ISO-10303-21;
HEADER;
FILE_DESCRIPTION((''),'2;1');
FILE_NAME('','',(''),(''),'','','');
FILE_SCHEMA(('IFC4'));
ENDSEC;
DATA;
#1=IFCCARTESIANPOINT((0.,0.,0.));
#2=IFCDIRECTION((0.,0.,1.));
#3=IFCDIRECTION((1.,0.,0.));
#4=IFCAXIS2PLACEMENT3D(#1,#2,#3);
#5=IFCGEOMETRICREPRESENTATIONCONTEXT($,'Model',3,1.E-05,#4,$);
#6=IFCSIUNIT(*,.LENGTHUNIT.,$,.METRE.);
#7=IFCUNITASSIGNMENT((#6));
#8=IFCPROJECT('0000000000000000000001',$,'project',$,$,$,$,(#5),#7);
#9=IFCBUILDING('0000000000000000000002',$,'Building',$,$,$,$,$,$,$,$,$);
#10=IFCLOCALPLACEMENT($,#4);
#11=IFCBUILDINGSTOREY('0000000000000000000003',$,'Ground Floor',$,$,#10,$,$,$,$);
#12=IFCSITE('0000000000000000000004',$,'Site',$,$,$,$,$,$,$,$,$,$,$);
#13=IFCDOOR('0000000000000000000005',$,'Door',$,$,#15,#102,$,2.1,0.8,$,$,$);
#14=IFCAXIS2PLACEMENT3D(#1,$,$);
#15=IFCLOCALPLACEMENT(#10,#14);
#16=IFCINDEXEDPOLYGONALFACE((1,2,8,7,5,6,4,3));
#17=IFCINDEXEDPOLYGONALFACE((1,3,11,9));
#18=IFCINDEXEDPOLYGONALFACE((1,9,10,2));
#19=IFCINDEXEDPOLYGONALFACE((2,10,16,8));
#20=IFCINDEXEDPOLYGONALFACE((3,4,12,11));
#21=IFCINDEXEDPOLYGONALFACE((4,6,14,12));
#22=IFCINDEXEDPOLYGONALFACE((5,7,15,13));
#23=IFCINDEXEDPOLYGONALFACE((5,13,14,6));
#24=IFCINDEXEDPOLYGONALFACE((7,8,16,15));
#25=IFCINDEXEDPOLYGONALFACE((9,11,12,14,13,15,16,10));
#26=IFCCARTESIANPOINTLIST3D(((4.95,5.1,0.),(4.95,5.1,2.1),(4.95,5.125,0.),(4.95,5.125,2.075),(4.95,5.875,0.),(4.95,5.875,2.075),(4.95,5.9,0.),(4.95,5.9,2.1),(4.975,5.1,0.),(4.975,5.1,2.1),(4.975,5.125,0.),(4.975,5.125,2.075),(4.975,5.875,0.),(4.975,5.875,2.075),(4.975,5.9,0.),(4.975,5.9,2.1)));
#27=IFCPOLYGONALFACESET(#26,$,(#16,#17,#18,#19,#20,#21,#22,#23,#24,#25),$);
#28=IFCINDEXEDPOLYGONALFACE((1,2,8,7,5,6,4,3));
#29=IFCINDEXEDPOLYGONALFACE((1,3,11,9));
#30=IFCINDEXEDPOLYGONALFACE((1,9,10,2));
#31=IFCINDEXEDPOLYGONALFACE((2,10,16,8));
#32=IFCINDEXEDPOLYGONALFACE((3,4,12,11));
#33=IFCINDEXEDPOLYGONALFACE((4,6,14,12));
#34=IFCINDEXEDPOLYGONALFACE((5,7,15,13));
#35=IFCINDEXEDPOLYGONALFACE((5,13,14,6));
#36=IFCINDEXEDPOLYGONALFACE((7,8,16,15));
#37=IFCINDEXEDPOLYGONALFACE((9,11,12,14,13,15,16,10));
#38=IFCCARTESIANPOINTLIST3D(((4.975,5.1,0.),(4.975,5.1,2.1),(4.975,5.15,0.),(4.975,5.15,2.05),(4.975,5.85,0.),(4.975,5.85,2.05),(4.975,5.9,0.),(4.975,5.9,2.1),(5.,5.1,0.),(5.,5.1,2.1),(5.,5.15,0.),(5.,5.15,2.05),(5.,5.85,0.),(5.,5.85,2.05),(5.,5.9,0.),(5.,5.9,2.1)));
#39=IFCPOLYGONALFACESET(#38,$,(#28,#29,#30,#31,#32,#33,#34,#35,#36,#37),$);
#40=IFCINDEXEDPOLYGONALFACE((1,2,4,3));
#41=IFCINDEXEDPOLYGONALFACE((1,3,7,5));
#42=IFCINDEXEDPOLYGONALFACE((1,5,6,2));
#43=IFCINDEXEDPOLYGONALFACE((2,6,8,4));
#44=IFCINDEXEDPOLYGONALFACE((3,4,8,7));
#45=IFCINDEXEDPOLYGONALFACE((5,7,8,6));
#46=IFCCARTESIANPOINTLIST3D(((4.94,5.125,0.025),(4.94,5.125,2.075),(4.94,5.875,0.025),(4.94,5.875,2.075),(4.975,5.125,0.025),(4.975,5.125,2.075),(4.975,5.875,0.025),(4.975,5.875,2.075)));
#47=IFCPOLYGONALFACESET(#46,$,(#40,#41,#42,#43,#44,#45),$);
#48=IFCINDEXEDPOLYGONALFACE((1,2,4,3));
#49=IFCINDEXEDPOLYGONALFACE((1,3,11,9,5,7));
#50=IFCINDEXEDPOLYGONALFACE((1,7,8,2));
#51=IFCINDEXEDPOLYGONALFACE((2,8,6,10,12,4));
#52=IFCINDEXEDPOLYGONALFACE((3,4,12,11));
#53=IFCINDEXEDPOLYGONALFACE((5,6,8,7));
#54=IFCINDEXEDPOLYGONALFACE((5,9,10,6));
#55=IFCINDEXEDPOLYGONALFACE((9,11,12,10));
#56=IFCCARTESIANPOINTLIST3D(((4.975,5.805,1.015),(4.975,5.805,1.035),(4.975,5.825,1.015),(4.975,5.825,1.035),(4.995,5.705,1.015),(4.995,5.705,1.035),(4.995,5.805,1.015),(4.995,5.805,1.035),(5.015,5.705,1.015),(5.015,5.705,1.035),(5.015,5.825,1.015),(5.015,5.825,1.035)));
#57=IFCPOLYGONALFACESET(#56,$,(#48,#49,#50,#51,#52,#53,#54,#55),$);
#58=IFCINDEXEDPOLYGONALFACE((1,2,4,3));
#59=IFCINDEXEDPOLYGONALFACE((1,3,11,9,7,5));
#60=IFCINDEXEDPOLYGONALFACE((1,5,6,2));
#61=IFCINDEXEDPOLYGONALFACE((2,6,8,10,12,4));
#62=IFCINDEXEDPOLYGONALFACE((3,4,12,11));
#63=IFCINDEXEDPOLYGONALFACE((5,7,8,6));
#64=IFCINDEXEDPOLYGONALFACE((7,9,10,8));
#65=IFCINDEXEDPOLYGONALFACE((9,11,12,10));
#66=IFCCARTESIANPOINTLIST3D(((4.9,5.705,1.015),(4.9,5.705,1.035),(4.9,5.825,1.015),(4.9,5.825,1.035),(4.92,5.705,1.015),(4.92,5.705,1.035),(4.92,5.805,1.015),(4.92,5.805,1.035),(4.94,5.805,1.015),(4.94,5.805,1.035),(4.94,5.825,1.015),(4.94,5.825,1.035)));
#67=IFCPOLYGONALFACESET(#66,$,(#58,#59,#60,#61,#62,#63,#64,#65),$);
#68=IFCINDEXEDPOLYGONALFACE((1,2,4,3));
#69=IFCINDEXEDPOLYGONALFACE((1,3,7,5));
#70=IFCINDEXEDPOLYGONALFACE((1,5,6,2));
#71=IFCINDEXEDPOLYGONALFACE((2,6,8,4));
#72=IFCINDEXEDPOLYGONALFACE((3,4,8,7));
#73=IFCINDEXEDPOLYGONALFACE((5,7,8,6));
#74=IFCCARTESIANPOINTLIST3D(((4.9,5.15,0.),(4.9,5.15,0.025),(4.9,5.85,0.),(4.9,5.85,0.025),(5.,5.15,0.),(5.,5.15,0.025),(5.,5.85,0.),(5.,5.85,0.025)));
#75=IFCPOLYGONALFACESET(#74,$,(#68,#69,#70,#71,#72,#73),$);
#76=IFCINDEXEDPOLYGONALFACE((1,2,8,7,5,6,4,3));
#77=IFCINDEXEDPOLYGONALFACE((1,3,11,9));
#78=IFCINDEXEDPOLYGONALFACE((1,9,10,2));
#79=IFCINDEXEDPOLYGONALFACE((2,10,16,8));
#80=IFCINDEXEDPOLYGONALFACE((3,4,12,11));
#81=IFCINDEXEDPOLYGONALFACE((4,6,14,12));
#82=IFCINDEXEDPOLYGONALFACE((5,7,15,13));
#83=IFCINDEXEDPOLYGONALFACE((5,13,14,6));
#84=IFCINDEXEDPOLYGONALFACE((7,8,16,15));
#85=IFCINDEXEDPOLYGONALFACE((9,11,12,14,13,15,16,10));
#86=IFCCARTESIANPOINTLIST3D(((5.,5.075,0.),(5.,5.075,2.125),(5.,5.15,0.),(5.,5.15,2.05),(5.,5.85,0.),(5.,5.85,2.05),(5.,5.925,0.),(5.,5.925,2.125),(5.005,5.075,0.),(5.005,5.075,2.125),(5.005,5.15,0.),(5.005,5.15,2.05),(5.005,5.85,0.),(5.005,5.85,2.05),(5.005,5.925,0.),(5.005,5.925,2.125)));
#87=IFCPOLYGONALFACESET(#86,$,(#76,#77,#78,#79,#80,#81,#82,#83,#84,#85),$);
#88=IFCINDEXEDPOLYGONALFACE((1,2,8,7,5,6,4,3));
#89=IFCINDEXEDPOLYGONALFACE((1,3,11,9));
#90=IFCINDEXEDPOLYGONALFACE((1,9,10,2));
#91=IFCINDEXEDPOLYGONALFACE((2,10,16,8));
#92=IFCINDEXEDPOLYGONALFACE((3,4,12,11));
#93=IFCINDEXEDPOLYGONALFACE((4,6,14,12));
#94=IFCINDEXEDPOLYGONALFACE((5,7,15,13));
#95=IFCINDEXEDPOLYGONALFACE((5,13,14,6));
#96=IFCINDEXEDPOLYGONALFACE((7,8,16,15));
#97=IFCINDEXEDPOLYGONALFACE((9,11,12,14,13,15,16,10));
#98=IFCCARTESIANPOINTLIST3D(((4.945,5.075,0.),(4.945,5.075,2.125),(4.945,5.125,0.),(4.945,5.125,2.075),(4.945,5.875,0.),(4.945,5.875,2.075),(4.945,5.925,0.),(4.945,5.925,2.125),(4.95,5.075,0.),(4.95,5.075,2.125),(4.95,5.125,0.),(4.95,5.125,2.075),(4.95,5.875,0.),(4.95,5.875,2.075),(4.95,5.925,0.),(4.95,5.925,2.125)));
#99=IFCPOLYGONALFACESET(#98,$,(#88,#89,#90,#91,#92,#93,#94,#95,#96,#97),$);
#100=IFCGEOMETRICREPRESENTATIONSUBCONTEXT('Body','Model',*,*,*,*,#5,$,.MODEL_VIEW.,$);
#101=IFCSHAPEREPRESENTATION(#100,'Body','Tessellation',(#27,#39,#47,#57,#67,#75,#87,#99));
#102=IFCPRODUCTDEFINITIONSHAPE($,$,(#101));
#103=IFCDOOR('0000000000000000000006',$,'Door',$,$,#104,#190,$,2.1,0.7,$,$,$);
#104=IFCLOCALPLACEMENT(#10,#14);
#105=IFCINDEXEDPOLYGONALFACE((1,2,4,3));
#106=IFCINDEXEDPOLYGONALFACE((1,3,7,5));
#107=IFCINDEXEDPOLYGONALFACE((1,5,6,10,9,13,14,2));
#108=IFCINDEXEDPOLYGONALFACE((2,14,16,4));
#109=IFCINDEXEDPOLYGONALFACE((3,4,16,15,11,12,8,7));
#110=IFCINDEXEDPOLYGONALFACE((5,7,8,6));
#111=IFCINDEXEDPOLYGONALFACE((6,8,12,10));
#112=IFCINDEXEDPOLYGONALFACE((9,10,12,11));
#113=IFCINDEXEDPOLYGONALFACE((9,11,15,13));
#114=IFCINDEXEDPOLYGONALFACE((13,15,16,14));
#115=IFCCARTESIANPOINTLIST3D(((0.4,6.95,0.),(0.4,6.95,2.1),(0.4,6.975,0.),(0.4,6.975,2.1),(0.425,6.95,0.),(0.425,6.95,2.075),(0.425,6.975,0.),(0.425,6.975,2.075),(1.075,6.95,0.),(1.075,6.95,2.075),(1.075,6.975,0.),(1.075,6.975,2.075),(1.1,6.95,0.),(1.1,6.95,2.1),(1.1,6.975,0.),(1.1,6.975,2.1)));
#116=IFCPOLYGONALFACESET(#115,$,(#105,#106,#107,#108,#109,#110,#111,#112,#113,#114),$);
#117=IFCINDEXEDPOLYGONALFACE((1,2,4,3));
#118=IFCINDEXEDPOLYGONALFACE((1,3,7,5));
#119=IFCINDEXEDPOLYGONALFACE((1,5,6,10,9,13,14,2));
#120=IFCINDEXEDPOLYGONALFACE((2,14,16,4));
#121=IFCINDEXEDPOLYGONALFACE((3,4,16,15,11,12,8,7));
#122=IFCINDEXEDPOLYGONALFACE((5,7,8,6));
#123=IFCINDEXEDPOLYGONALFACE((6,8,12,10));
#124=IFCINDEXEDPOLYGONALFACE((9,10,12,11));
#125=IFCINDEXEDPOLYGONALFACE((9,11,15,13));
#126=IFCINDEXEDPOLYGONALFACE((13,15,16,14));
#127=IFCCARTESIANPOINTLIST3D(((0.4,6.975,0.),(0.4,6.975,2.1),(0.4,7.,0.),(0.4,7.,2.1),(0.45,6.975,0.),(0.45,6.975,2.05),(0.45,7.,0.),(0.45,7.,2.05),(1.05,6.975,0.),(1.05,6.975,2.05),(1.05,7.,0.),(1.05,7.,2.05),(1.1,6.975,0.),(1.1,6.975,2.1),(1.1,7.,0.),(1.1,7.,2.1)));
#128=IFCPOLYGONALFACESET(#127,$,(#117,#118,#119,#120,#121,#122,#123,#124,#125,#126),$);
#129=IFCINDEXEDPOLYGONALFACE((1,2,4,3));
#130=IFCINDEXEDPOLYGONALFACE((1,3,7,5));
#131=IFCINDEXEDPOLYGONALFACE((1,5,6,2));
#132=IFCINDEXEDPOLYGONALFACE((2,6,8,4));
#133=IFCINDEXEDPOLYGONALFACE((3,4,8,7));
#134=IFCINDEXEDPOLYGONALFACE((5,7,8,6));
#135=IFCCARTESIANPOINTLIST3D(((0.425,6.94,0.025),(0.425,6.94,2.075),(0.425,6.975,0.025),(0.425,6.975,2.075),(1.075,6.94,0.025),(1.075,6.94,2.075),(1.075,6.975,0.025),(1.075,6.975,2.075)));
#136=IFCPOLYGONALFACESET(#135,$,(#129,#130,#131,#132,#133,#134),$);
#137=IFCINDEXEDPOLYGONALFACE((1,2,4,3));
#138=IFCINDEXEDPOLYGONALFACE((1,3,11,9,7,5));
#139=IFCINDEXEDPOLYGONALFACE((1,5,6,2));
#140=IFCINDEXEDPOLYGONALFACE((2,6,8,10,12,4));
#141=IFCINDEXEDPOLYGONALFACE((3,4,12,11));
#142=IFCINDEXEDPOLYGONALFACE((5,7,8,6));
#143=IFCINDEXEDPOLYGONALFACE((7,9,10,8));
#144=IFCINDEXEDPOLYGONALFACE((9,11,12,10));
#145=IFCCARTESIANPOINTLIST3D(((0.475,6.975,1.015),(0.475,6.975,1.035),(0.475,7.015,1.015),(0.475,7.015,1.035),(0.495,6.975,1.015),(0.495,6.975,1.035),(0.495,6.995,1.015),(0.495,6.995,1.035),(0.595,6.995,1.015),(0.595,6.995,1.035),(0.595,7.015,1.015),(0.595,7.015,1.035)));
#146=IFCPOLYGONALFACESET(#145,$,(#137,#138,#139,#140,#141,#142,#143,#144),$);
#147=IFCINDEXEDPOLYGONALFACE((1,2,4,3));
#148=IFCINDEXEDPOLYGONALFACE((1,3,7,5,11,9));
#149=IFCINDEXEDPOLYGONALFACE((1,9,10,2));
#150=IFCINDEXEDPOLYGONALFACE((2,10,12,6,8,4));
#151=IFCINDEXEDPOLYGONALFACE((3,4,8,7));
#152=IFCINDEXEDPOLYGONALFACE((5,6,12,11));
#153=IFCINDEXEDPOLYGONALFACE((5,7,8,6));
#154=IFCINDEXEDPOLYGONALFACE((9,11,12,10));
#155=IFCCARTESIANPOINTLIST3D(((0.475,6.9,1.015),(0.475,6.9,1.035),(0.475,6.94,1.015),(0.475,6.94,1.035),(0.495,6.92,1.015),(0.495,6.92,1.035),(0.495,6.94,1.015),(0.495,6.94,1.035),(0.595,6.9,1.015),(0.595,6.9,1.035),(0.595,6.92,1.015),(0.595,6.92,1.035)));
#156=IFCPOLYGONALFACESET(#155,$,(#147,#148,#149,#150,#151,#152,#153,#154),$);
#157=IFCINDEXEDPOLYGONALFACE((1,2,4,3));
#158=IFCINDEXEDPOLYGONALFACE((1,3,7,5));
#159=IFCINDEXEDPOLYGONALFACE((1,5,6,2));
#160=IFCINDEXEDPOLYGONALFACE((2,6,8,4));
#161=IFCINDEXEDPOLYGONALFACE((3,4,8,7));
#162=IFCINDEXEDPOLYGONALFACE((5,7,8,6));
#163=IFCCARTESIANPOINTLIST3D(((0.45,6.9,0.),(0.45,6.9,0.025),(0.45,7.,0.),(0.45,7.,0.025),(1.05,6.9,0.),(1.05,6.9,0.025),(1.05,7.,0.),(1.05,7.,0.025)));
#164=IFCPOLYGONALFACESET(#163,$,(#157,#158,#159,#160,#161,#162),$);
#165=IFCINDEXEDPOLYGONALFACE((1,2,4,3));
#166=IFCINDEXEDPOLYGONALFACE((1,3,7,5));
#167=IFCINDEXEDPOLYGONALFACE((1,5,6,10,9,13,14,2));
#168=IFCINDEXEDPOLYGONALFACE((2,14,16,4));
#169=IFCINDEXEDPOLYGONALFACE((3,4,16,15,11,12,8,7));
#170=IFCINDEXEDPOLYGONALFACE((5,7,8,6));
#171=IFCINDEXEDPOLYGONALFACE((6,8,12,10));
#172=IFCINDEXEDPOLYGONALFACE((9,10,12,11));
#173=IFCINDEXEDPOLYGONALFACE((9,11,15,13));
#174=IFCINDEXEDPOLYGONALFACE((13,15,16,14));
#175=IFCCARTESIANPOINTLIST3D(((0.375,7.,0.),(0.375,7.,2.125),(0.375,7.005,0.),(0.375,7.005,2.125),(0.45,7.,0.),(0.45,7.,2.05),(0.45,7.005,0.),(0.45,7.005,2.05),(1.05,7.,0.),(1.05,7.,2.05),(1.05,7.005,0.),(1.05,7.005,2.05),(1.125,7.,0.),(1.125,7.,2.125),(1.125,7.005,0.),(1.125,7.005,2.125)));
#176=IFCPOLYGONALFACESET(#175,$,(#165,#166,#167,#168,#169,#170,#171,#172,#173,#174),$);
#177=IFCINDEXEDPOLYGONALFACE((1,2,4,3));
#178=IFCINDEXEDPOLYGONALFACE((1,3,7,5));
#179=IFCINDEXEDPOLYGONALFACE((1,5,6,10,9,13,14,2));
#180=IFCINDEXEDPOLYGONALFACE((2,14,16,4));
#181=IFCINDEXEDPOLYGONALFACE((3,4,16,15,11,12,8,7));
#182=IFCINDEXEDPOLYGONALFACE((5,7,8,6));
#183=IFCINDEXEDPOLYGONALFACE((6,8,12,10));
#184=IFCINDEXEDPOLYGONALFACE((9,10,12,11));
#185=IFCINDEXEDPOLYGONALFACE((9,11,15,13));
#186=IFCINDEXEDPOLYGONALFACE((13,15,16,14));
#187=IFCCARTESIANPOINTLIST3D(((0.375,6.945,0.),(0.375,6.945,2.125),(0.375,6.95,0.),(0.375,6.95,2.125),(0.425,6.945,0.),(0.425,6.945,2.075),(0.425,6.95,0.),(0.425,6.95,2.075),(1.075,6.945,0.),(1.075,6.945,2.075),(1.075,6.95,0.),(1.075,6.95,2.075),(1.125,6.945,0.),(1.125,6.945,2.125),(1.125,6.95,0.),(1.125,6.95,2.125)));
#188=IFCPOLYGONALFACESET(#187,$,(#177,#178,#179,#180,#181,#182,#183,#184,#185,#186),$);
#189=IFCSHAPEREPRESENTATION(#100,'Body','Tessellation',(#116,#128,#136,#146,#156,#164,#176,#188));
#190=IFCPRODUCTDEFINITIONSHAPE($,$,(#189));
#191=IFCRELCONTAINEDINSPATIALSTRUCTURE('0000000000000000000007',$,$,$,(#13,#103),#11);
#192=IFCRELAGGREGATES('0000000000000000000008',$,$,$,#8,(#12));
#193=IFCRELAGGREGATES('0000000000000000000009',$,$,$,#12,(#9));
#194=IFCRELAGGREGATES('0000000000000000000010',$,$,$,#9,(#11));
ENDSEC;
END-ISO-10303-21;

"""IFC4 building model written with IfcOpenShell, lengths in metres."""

from ifc_helpers import new_model, si_unit, frame, origin_with_axes, place, context, subcontext, project, spatial, line, indexed_curve, outline, extrude, element, save


model = new_model("IFC4")

# Units and contexts
model_context = context("Model", 3, precision=1e-05, world=origin_with_axes())
body_context = subcontext(model_context, "Body", "Model", "MODEL_VIEW")
ifc_project = project(units=[si_unit("LENGTHUNIT", "METRE")], contexts=[model_context])

# Site, building, storey
site = spatial("IfcSite", under=ifc_project, Name="Site")
building = spatial("IfcBuilding", under=site, Name="Building")
storey_placement = place(None, origin_with_axes())
storey = spatial("IfcBuildingStorey", under=building, at=storey_placement, Name="Ground Floor")

# Doors
door_1_placement = place(storey_placement, frame((5.0, 5.1, 0.0), z_axis=(0.0, 0.0, 1.0), x_axis=(0.0, 1.0, 0.0)))
element("IfcDoor", 1, at=door_1_placement, inside=storey, Name="Door", OverallHeight=2.1, OverallWidth=0.8, context=body_context, shape_type="SweptSolid", body=[
    extrude(outline(indexed_curve([(0.0, 0.0), (0.0, 2.1), (0.8, 2.1), (0.8, 0.0), (0.775, 0.0), (0.775, 2.075), (0.025, 2.075), (0.025, 0.0)], segments=[line(1, 2, 3, 4, 5, 6, 7, 8, 1)])), frame((0.0, 0.025, 0.0), z_axis=(0.0, -1.0, 0.0), x_axis=(1.0, 0.0, 0.0)), (0.0, 0.0, -1.0), 0.025),
    extrude(outline(indexed_curve([(0.0, 0.0), (0.0, 2.1), (0.8, 2.1), (0.8, 0.0), (0.75, 0.0), (0.75, 2.05), (0.05, 2.05), (0.05, 0.0)], segments=[line(1, 2, 3, 4, 5, 6, 7, 8, 1)])), frame((0.0, 0.0, 0.0), z_axis=(0.0, -1.0, 0.0), x_axis=(1.0, 0.0, 0.0)), (0.0, 0.0, -1.0), 0.025),
    extrude(outline(indexed_curve([(0.0, 0.0), (0.75, 0.0), (0.75, 0.035), (0.0, 0.035)], segments=[line(1, 2, 3, 4, 1)])), frame((0.025, 0.025, 0.025), z_axis=(0.0, 0.0, 1.0), x_axis=(1.0, 0.0, 0.0)), (0.0, 0.0, 1.0), 2.05),
    extrude(outline(indexed_curve([(0.0, 0.0), (0.0, -0.04), (-0.12, -0.04), (-0.12, -0.02), (-0.02, -0.02), (-0.02, 0.0)], segments=[line(1, 2, 3, 4, 5, 6, 1)])), frame((0.725, 0.025, 1.015), z_axis=(0.0, 0.0, 1.0), x_axis=(1.0, 0.0, 0.0)), (0.0, 0.0, 1.0), 0.02),
    extrude(outline(indexed_curve([(0.0, 0.0), (0.0, 0.04), (-0.12, 0.04), (-0.12, 0.02), (-0.02, 0.02), (-0.02, 0.0)], segments=[line(1, 2, 3, 4, 5, 6, 1)])), frame((0.725, 0.06, 1.015), z_axis=(0.0, 0.0, 1.0), x_axis=(1.0, 0.0, 0.0)), (0.0, 0.0, 1.0), 0.02),
    extrude(outline(indexed_curve([(0.0, 0.0), (0.7, 0.0), (0.7, 0.1), (0.0, 0.1)], segments=[line(1, 2, 3, 4, 1)])), frame((0.05, 0.0, 0.0), z_axis=(0.0, 0.0, 1.0), x_axis=(1.0, 0.0, 0.0)), (0.0, 0.0, 1.0), 0.025),
    extrude(outline(indexed_curve([(0.0, 0.0), (0.0, 2.125), (0.85, 2.125), (0.85, 0.0), (0.775, 0.0), (0.775, 2.05), (0.075, 2.05), (0.075, 0.0)], segments=[line(1, 2, 3, 4, 5, 6, 7, 8, 1)])), frame((-0.025, -0.005, 0.0), z_axis=(0.0, -1.0, 0.0), x_axis=(1.0, 0.0, 0.0)), (0.0, 0.0, -1.0), 0.005),
    extrude(outline(indexed_curve([(0.0, 0.0), (0.0, 2.125), (0.85, 2.125), (0.85, 0.0), (0.8, 0.0), (0.8, 2.075), (0.05, 2.075), (0.05, 0.0)], segments=[line(1, 2, 3, 4, 5, 6, 7, 8, 1)])), frame((-0.025, 0.05, 0.0), z_axis=(0.0, -1.0, 0.0), x_axis=(1.0, 0.0, 0.0)), (0.0, 0.0, -1.0), 0.005),
])
door_2_placement = place(storey_placement, frame((1.1, 7.0, 0.0), z_axis=(0.0, 0.0, 1.0), x_axis=(-1.0, 0.0, 0.0)))
element("IfcDoor", 2, at=door_2_placement, inside=storey, Name="Door", OverallHeight=2.1, OverallWidth=0.7, context=body_context, shape_type="SweptSolid", body=[
    extrude(outline(indexed_curve([(0.0, 0.0), (0.0, 2.1), (0.7, 2.1), (0.7, 0.0), (0.675, 0.0), (0.675, 2.075), (0.025, 2.075), (0.025, 0.0)], segments=[line(1, 2, 3, 4, 5, 6, 7, 8, 1)])), frame((0.0, 0.025, 0.0), z_axis=(0.0, -1.0, 0.0), x_axis=(1.0, 0.0, 0.0)), (0.0, 0.0, -1.0), 0.025),
    extrude(outline(indexed_curve([(0.0, 0.0), (0.0, 2.1), (0.7, 2.1), (0.7, 0.0), (0.65, 0.0), (0.65, 2.05), (0.05, 2.05), (0.05, 0.0)], segments=[line(1, 2, 3, 4, 5, 6, 7, 8, 1)])), frame((0.0, 0.0, 0.0), z_axis=(0.0, -1.0, 0.0), x_axis=(1.0, 0.0, 0.0)), (0.0, 0.0, -1.0), 0.025),
    extrude(outline(indexed_curve([(0.0, 0.0), (0.65, 0.0), (0.65, 0.035), (0.0, 0.035)], segments=[line(1, 2, 3, 4, 1)])), frame((0.025, 0.025, 0.025), z_axis=(0.0, 0.0, 1.0), x_axis=(1.0, 0.0, 0.0)), (0.0, 0.0, 1.0), 2.05),
    extrude(outline(indexed_curve([(0.0, 0.0), (0.0, -0.04), (-0.12, -0.04), (-0.12, -0.02), (-0.02, -0.02), (-0.02, 0.0)], segments=[line(1, 2, 3, 4, 5, 6, 1)])), frame((0.625, 0.025, 1.015), z_axis=(0.0, 0.0, 1.0), x_axis=(1.0, 0.0, 0.0)), (0.0, 0.0, 1.0), 0.02),
    extrude(outline(indexed_curve([(0.0, 0.0), (0.0, 0.04), (-0.12, 0.04), (-0.12, 0.02), (-0.02, 0.02), (-0.02, 0.0)], segments=[line(1, 2, 3, 4, 5, 6, 1)])), frame((0.625, 0.06, 1.015), z_axis=(0.0, 0.0, 1.0), x_axis=(1.0, 0.0, 0.0)), (0.0, 0.0, 1.0), 0.02),
    extrude(outline(indexed_curve([(0.0, 0.0), (0.6, 0.0), (0.6, 0.1), (0.0, 0.1)], segments=[line(1, 2, 3, 4, 1)])), frame((0.05, 0.0, 0.0), z_axis=(0.0, 0.0, 1.0), x_axis=(1.0, 0.0, 0.0)), (0.0, 0.0, 1.0), 0.025),
    extrude(outline(indexed_curve([(0.0, 0.0), (0.0, 2.125), (0.75, 2.125), (0.75, 0.0), (0.675, 0.0), (0.675, 2.05), (0.075, 2.05), (0.075, 0.0)], segments=[line(1, 2, 3, 4, 5, 6, 7, 8, 1)])), frame((-0.025, -0.005, 0.0), z_axis=(0.0, -1.0, 0.0), x_axis=(1.0, 0.0, 0.0)), (0.0, 0.0, -1.0), 0.005),
    extrude(outline(indexed_curve([(0.0, 0.0), (0.0, 2.125), (0.75, 2.125), (0.75, 0.0), (0.7, 0.0), (0.7, 2.075), (0.05, 2.075), (0.05, 0.0)], segments=[line(1, 2, 3, 4, 5, 6, 7, 8, 1)])), frame((-0.025, 0.05, 0.0), z_axis=(0.0, -1.0, 0.0), x_axis=(1.0, 0.0, 0.0)), (0.0, 0.0, -1.0), 0.005),
])

save(model, "model.ifc")
